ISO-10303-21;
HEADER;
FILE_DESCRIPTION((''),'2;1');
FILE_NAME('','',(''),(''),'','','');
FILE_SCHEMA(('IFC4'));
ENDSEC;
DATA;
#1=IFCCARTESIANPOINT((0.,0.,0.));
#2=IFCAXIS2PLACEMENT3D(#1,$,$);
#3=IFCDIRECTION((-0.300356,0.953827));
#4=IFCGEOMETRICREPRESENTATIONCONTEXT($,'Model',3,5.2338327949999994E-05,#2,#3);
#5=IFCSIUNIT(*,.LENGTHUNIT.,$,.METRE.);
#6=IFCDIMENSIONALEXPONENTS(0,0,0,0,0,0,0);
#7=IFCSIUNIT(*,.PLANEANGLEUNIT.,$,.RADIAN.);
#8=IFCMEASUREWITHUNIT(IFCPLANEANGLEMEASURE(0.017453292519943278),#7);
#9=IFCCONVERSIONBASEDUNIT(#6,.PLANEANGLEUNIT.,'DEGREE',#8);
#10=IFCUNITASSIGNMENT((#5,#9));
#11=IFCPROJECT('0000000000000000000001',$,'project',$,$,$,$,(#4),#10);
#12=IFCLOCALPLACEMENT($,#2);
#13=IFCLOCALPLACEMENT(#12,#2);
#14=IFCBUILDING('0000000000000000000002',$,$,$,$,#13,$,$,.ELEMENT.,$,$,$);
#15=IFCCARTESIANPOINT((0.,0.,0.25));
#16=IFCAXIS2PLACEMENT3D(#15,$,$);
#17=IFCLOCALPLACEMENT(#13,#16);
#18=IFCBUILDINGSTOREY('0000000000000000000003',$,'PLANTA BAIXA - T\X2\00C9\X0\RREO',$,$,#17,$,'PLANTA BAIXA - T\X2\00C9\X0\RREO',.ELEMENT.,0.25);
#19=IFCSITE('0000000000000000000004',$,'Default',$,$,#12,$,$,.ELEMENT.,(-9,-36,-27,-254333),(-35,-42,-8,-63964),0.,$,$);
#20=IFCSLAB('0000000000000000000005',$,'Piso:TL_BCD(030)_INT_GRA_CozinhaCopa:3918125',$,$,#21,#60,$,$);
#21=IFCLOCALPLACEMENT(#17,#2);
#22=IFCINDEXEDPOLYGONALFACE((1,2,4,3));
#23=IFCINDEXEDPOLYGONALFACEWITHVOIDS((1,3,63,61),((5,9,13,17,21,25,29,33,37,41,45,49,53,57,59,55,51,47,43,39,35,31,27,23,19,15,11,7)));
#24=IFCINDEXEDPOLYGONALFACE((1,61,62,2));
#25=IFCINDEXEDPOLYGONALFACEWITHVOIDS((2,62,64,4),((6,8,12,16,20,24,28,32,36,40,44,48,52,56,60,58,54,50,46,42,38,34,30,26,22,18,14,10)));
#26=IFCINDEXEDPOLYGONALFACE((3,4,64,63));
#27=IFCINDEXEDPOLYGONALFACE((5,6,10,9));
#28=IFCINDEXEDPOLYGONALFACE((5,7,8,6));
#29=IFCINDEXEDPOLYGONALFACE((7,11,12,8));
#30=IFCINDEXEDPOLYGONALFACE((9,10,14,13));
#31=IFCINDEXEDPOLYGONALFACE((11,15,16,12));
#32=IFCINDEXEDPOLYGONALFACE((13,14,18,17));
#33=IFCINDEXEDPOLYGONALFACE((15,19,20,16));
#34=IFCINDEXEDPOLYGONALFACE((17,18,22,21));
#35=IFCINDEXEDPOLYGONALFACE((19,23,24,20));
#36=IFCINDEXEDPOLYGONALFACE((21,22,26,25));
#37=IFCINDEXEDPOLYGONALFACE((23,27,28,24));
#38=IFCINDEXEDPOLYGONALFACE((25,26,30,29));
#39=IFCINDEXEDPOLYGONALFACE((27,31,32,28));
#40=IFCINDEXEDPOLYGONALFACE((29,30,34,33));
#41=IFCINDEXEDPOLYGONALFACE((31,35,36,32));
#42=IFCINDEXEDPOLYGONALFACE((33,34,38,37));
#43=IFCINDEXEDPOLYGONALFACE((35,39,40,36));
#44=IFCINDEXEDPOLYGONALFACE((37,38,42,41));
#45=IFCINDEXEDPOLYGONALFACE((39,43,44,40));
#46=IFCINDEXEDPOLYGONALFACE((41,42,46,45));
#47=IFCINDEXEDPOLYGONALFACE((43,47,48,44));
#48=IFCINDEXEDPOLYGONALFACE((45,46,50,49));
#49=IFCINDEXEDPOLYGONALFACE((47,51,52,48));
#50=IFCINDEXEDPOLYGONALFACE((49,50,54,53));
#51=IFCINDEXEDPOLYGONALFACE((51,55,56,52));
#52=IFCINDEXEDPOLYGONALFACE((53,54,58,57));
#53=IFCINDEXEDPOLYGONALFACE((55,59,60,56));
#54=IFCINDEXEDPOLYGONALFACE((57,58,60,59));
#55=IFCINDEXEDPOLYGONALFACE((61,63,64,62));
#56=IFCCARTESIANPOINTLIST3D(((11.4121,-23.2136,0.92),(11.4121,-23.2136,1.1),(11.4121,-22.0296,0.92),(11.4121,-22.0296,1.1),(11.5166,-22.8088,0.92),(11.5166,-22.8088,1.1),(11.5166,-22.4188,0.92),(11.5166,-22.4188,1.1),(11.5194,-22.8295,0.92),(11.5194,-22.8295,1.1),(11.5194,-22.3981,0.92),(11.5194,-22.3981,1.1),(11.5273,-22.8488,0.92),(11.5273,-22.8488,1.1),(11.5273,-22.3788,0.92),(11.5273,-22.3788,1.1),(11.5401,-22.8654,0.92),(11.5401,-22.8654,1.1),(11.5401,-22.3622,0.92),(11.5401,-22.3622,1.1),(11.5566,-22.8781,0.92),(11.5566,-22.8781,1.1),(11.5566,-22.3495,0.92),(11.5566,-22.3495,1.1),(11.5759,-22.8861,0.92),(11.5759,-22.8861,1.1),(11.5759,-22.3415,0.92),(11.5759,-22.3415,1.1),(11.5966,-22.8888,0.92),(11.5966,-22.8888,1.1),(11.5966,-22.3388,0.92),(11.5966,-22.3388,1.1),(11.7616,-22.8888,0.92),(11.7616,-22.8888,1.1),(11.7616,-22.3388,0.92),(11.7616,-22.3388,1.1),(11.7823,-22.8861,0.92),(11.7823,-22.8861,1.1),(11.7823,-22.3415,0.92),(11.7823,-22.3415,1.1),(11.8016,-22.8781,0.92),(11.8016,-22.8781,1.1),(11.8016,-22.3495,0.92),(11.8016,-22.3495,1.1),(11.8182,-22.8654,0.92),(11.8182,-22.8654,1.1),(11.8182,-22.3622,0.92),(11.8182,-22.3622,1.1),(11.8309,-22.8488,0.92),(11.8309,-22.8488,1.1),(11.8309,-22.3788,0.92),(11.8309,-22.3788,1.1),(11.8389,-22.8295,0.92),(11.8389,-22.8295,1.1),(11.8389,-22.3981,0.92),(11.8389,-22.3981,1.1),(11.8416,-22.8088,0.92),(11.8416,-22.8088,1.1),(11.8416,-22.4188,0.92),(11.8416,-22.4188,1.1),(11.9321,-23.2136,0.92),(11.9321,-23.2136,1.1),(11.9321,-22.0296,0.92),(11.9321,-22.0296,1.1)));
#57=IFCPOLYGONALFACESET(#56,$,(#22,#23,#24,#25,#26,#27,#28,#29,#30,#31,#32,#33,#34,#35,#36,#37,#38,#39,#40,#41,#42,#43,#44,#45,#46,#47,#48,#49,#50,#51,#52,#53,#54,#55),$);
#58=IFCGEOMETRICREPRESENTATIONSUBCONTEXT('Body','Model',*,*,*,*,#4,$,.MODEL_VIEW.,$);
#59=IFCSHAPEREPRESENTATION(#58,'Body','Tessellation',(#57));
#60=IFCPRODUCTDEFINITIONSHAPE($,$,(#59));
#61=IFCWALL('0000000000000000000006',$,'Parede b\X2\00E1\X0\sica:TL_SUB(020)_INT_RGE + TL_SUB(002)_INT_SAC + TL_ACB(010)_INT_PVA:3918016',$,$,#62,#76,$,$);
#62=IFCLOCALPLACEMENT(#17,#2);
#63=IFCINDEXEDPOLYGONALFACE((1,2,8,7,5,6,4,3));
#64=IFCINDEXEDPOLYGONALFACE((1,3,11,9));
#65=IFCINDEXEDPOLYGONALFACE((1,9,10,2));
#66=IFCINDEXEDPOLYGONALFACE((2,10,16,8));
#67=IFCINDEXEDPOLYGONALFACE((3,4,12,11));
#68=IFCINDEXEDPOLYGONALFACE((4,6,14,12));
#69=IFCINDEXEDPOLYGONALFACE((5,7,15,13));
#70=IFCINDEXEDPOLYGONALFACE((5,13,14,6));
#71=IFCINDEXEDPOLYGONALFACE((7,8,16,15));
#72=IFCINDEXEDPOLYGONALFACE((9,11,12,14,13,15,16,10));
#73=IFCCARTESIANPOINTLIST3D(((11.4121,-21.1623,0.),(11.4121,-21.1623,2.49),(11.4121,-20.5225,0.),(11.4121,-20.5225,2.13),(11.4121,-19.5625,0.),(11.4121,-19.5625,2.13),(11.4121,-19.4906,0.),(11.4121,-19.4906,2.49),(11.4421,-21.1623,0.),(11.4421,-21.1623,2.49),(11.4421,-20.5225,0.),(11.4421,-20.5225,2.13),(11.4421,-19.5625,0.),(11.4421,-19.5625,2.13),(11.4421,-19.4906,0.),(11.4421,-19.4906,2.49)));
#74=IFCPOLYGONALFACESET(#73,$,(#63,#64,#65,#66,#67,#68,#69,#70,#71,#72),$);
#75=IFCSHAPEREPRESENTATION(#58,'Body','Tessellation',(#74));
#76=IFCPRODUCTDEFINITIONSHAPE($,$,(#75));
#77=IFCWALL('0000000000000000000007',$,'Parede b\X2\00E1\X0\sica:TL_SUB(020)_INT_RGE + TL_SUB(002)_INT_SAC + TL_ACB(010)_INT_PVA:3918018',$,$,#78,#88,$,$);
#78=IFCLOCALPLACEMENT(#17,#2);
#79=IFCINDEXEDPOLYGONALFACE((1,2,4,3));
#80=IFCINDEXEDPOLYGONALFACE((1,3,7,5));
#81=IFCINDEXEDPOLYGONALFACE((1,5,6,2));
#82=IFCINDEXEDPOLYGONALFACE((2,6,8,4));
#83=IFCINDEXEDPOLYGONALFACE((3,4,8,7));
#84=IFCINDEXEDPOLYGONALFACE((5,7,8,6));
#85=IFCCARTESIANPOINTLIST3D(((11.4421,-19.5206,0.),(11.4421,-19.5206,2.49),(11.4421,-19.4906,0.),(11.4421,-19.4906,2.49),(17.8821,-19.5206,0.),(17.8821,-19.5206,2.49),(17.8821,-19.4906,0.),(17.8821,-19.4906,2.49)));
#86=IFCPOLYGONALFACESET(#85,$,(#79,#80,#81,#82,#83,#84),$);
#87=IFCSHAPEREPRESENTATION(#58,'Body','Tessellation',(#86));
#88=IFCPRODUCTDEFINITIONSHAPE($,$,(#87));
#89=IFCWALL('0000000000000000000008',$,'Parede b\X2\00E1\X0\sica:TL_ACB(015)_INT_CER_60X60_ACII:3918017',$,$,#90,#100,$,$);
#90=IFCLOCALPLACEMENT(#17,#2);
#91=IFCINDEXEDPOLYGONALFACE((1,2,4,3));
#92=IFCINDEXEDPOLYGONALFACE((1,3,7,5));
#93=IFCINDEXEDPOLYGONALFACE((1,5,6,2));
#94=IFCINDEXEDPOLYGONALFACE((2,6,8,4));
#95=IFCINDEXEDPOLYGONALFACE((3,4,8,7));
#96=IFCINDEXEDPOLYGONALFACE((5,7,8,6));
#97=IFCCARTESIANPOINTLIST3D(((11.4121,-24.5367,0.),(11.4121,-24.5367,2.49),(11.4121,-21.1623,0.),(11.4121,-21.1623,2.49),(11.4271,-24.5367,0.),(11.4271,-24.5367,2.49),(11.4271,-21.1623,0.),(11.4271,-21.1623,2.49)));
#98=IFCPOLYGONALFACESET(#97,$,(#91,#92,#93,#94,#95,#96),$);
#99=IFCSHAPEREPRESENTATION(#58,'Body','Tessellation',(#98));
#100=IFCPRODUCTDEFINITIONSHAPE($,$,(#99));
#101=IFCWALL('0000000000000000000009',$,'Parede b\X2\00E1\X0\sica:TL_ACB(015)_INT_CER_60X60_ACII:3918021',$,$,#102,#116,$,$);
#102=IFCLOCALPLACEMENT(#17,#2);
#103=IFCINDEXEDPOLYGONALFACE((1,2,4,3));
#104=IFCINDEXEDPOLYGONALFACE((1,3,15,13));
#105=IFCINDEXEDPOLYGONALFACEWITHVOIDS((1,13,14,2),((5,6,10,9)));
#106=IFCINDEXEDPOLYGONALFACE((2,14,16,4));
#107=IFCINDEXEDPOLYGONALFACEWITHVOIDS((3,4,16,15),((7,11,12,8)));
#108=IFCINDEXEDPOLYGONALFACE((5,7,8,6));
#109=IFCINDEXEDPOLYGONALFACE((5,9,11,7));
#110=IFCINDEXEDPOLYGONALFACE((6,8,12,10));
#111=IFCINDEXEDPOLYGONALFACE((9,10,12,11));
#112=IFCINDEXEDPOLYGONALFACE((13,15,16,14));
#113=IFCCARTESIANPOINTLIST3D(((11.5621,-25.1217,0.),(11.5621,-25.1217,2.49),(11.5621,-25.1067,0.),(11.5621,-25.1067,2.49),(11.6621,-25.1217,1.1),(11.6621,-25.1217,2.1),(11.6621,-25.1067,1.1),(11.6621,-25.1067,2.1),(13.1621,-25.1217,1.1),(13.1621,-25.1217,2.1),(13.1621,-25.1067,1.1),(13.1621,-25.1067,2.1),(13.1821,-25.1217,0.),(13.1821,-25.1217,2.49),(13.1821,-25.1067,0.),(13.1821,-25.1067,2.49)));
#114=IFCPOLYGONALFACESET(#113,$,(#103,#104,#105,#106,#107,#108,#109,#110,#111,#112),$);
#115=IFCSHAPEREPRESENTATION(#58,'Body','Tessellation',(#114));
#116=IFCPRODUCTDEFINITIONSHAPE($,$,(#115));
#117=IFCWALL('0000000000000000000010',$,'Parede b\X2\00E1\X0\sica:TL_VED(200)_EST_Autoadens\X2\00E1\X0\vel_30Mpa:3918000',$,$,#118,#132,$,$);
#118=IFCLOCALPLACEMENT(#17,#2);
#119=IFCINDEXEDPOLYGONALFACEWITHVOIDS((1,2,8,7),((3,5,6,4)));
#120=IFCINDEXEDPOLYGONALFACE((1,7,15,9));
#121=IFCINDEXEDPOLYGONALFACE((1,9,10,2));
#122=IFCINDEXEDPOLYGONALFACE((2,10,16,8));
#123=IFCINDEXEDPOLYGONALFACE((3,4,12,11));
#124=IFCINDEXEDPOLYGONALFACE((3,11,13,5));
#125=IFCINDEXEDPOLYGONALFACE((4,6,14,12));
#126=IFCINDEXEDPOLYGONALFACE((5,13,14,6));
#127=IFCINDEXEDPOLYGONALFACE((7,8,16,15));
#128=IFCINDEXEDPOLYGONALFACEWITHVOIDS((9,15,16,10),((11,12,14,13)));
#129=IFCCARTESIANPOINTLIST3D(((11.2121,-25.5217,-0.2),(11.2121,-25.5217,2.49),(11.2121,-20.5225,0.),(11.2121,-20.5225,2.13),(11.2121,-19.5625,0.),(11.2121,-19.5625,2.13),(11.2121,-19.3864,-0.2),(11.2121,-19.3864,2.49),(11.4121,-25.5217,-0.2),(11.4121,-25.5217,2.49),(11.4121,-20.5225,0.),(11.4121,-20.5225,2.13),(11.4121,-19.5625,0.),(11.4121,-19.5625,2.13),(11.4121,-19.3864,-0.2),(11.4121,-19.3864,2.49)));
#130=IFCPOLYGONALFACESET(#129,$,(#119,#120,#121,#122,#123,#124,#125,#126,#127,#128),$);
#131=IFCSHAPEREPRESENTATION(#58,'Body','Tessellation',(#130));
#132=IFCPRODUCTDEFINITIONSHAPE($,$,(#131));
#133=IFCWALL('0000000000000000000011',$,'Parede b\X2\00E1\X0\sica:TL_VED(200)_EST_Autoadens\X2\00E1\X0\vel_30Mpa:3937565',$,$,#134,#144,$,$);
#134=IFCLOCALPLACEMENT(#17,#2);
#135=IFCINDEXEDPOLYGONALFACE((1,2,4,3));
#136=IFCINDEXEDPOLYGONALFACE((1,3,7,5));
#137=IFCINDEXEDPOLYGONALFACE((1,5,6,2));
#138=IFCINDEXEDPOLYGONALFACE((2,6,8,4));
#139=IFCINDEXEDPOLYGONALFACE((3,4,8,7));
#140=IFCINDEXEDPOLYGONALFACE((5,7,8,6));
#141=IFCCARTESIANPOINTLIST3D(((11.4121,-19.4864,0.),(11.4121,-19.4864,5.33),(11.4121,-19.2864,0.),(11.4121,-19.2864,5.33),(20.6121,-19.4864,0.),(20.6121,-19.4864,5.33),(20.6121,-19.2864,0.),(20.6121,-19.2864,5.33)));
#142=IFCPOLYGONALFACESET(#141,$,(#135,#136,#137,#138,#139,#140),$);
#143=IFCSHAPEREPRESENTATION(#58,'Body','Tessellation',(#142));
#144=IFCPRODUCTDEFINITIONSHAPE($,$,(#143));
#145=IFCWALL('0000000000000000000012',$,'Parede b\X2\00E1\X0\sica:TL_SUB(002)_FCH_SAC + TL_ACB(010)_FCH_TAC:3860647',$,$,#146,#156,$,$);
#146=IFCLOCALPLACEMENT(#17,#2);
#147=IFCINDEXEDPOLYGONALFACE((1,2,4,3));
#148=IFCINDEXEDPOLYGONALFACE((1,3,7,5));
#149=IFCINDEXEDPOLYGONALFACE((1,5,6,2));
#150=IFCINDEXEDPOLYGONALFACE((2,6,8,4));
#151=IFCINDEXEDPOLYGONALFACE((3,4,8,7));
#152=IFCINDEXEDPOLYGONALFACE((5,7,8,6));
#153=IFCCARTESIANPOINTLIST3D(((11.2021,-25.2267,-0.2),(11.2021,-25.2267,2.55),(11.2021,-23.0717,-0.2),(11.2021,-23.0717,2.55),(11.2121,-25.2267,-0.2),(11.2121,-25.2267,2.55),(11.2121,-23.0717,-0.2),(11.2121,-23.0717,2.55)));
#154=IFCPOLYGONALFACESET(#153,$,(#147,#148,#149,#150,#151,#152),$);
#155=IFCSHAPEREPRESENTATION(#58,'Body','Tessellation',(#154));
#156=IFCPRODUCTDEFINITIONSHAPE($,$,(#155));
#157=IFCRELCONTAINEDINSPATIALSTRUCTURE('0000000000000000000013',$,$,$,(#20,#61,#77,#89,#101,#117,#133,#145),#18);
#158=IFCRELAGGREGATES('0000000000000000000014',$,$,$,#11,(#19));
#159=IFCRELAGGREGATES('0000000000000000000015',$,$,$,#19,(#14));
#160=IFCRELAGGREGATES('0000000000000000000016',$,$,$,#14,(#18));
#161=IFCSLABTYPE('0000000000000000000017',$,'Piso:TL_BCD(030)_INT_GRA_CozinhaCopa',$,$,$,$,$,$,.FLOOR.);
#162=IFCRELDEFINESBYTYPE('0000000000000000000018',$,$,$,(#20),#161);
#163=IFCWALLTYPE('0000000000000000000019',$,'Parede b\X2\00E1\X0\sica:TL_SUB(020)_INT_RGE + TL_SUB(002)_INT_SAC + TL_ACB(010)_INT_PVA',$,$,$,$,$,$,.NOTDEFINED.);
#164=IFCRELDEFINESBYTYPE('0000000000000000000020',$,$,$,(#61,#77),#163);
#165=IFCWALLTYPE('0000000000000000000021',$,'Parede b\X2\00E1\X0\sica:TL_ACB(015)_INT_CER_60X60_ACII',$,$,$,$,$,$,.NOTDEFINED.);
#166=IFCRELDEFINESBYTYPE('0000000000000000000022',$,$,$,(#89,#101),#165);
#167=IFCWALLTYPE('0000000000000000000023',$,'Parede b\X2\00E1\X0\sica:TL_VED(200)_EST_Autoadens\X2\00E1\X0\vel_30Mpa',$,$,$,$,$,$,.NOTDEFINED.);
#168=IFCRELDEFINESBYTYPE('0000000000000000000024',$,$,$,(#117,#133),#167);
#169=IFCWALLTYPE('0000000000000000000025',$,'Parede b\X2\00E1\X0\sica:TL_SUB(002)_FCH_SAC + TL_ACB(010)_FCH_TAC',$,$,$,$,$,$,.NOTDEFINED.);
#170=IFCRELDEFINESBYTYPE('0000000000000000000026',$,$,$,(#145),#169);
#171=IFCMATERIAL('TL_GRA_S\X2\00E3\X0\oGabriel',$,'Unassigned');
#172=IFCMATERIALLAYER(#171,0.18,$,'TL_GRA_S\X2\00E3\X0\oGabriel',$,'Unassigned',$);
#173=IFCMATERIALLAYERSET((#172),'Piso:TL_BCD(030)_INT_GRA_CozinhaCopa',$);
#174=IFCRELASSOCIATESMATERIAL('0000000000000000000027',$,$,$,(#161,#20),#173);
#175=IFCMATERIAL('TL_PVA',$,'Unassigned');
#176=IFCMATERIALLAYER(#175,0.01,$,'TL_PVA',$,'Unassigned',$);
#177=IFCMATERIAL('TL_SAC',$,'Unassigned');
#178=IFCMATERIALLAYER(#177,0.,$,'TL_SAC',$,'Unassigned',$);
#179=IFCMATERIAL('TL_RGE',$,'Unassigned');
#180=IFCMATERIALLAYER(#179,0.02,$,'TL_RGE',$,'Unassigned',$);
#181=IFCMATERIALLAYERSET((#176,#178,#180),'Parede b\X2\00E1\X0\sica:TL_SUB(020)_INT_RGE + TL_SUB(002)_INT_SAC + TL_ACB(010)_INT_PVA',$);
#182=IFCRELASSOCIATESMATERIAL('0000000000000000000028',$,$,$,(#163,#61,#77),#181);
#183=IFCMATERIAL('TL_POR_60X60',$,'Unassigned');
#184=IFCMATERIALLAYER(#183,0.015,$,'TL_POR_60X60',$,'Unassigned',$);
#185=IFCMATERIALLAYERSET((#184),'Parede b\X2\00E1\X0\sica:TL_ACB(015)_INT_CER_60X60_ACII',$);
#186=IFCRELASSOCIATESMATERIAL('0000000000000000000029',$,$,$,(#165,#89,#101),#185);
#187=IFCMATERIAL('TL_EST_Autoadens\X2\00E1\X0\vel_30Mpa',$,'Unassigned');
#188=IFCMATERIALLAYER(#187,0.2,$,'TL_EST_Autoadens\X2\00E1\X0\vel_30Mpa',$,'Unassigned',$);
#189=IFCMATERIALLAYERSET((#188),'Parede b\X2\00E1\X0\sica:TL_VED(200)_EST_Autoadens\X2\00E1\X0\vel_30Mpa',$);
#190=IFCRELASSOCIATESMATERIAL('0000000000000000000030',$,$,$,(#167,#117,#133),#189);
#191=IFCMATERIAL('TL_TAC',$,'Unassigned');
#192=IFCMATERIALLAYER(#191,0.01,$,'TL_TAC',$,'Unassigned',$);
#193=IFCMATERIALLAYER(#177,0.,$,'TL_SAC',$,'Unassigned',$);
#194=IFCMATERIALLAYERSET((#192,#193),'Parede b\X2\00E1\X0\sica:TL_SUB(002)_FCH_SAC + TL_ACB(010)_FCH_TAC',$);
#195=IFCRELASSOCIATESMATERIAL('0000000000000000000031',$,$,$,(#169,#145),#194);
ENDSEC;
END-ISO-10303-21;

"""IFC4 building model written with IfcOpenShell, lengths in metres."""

from ifc_helpers import new_model, entity, si_unit, converted_unit, direction, frame, frame_2d, origin, place, context, subcontext, project, spatial, polyline, circle_curve, parameter, trimmed, segment, composite_curve, rectangle, outline, extrude, material, layer, layer_set, layer_usage, type_object, element, save


model = new_model("IFC4")

# Units and contexts
model_context = context("Model", 3, precision=5.2338327949999994e-05, world=origin(), true_north=direction((-0.300356, 0.953827)))
body_context = subcontext(model_context, "Body", "Model", "MODEL_VIEW")
ifc_project = project(units=[si_unit("LENGTHUNIT", "METRE"), converted_unit("PLANEANGLEUNIT", "DEGREE", entity("IfcPlaneAngleMeasure", 0.017453292519943278), si_unit("PLANEANGLEUNIT", "RADIAN"), dimensions=[0, 0, 0, 0, 0, 0, 0])], contexts=[model_context])

# Site, building, storey
site_placement = place(None, origin())
site = spatial("IfcSite", under=ifc_project, at=site_placement, Name="Default", CompositionType="ELEMENT", RefLatitude=(-9, -36, -27, -254333), RefLongitude=(-35, -42, -8, -63964), RefElevation=0.0)
building_placement = place(site_placement, origin())
building = spatial("IfcBuilding", under=site, at=building_placement, CompositionType="ELEMENT")
storey_placement = place(building_placement, frame((0.0, 0.0, 0.25)))
storey = spatial("IfcBuildingStorey", under=building, at=storey_placement, Name="PLANTA BAIXA - TÉRREO", LongName="PLANTA BAIXA - TÉRREO", CompositionType="ELEMENT", Elevation=0.25)

# Shared definitions
ifc_material_1 = material(Name="TL_POR_60X60", Category="Unassigned")

# Slab, opening
ifc_material_2 = material(Name="TL_GRA_SãoGabriel", Category="Unassigned")
ifc_layer_1 = layer(ifc_material_2, 0.18, Name="TL_GRA_SãoGabriel", Category="Unassigned")
ifc_layer_set_1 = layer_set([ifc_layer_1], Name="Piso:TL_BCD(030)_INT_GRA_CozinhaCopa")
ifc_layer_usage_1 = layer_usage(ifc_layer_set_1, "AXIS3", "POSITIVE", 0.0)
slab_type_1 = type_object("IfcSlabType", Name="Piso:TL_BCD(030)_INT_GRA_CozinhaCopa", PredefinedType="FLOOR", material=ifc_layer_set_1)
slab_1_placement = place(storey_placement, frame((11.4121, -23.2136, 0.92)))
slab_1 = element("IfcSlab", 1, at=slab_1_placement, inside=storey, type_object=slab_type_1, material=ifc_layer_usage_1, Name="Piso:TL_BCD(030)_INT_GRA_CozinhaCopa:3918125", context=body_context, shape_type="SweptSolid", body=[
    extrude(rectangle(XDim=1.184, YDim=0.52, at=frame_2d((0.0, 0.0), x_axis=(0.0, 1.0))), frame((0.26, 0.592, 0.18), z_axis=(0.0, 0.0, -1.0), x_axis=(-1.0, 0.0, 0.0)), (0.0, 0.0, 1.0), 0.18),
])
opening_1_placement = place(slab_1_placement, frame((-11.4121, 23.2136, 0.18)))
element("IfcOpeningElement", 2, at=opening_1_placement, cuts=slab_1, PredefinedType="OPENING", context=body_context, shape_type="SweptSolid", body=[
    extrude(outline(composite_curve([segment(polyline([(-0.195, -0.1625), (0.195, -0.1625)]), True, "CONTINUOUS"), segment(trimmed(circle_curve(frame_2d((0.195, -0.0825), x_axis=(-1.0, 0.0)), 0.08), [parameter(90.0)], [parameter(180.0)], True, "PARAMETER"), True, "CONTINUOUS"), segment(polyline([(0.275, -0.0825), (0.275, 0.0825)]), True, "CONTINUOUS"), segment(trimmed(circle_curve(frame_2d((0.195, 0.0825), x_axis=(-1.0, 0.0)), 0.08), [parameter(180.0)], [parameter(270.0)], True, "PARAMETER"), True, "CONTINUOUS"), segment(polyline([(0.195, 0.1625), (-0.195, 0.1625)]), True, "CONTINUOUS"), segment(trimmed(circle_curve(frame_2d((-0.195, 0.0825), x_axis=(-1.0, 0.0)), 0.08), [parameter(270.0)], [parameter(360.0)], True, "PARAMETER"), True, "CONTINUOUS"), segment(polyline([(-0.275, 0.0825), (-0.275, -0.0825)]), True, "CONTINUOUS"), segment(trimmed(circle_curve(frame_2d((-0.195, -0.0825), x_axis=(-1.0, 0.0)), 0.08), [parameter(360.0)], [parameter(90.0)], True, "PARAMETER"), True, "CONTINUOUS")], self_intersect=False)), frame((11.6791, -22.6138, -0.21), z_axis=(0.0, 0.0, 1.0), x_axis=(0.0, -1.0, 0.0)), (0.0, 0.0, 1.0), 0.21),
])

# Wall, opening
ifc_material_3 = material(Name="TL_PVA", Category="Unassigned")
ifc_layer_2 = layer(ifc_material_3, 0.01, Name="TL_PVA", Category="Unassigned")
ifc_material_4 = material(Name="TL_SAC", Category="Unassigned")
ifc_layer_3 = layer(ifc_material_4, 0.0, Name="TL_SAC", Category="Unassigned")
ifc_material_5 = material(Name="TL_RGE", Category="Unassigned")
ifc_layer_4 = layer(ifc_material_5, 0.02, Name="TL_RGE", Category="Unassigned")
ifc_layer_set_2 = layer_set([ifc_layer_2, ifc_layer_3, ifc_layer_4], Name="Parede básica:TL_SUB(020)_INT_RGE + TL_SUB(002)_INT_SAC + TL_ACB(010)_INT_PVA")
ifc_layer_usage_2 = layer_usage(ifc_layer_set_2, "AXIS2", "NEGATIVE", 0.015)
wall_type_1 = type_object("IfcWallType", Name="Parede básica:TL_SUB(020)_INT_RGE + TL_SUB(002)_INT_SAC + TL_ACB(010)_INT_PVA", PredefinedType="NOTDEFINED", material=ifc_layer_set_2)
wall_1_placement = place(storey_placement, frame((11.4271, -19.4906, 0.0), z_axis=(0.0, 0.0, 1.0), x_axis=(0.0, -1.0, 0.0)))
wall_1 = element("IfcWall", 3, at=wall_1_placement, inside=storey, type_object=wall_type_1, material=ifc_layer_usage_2, Name="Parede básica:TL_SUB(020)_INT_RGE + TL_SUB(002)_INT_SAC + TL_ACB(010)_INT_PVA:3918016", context=body_context, shape_type="SweptSolid", body=[
    extrude(rectangle(XDim=1.6717, YDim=0.03, at=frame_2d((0.8359, 0.0), x_axis=(-1.0, 0.0))), origin(), (0.0, 0.0, 1.0), 2.49),
])
opening_2_placement = place(wall_1_placement, frame((-19.4906, -11.4271, 0.0)))
element("IfcOpeningElement", 4, at=opening_2_placement, cuts=wall_1, PredefinedType="OPENING", context=body_context, shape_type="SweptSolid", body=[
    extrude(rectangle(XDim=2.13, YDim=0.96, at=frame_2d((0.0, 0.0), x_axis=(0.0, 1.0))), frame((20.0425, 9.8881, 1.065), z_axis=(0.0, 1.0, 0.0), x_axis=(-1.0, 0.0, 0.0)), (0.0, 0.0, 1.0), 3.048),
])

# Walls
ifc_layer_usage_3 = layer_usage(ifc_layer_set_2, "AXIS2", "POSITIVE", -0.015)
wall_2_placement = place(storey_placement, frame((11.4421, -19.5056, 0.0)))
element("IfcWall", 5, at=wall_2_placement, inside=storey, type_object=wall_type_1, material=ifc_layer_usage_3, Name="Parede básica:TL_SUB(020)_INT_RGE + TL_SUB(002)_INT_SAC + TL_ACB(010)_INT_PVA:3918018", context=body_context, shape_type="SweptSolid", body=[
    extrude(rectangle(XDim=6.44, YDim=0.03, at=frame_2d((3.22, 0.0), x_axis=(-1.0, 0.0))), origin(), (0.0, 0.0, 1.0), 2.49),
])
ifc_layer_5 = layer(ifc_material_1, 0.015, Name="TL_POR_60X60", Category="Unassigned")
ifc_layer_set_3 = layer_set([ifc_layer_5], Name="Parede básica:TL_ACB(015)_INT_CER_60X60_ACII")
ifc_layer_usage_4 = layer_usage(ifc_layer_set_3, "AXIS2", "NEGATIVE", 0.0075)
wall_type_2 = type_object("IfcWallType", Name="Parede básica:TL_ACB(015)_INT_CER_60X60_ACII", PredefinedType="NOTDEFINED", material=ifc_layer_set_3)
wall_3_placement = place(storey_placement, frame((11.4196, -21.1623, 0.0), z_axis=(0.0, 0.0, 1.0), x_axis=(0.0, -1.0, 0.0)))
element("IfcWall", 6, at=wall_3_placement, inside=storey, type_object=wall_type_2, material=ifc_layer_usage_4, Name="Parede básica:TL_ACB(015)_INT_CER_60X60_ACII:3918017", context=body_context, shape_type="SweptSolid", body=[
    extrude(rectangle(XDim=3.3744, YDim=0.015, at=frame_2d((1.6872, 0.0), x_axis=(-1.0, 0.0))), origin(), (0.0, 0.0, 1.0), 2.49),
])

# Walls, openings
ifc_layer_usage_5 = layer_usage(ifc_layer_set_3, "AXIS2", "NEGATIVE", 0.0075)
wall_4_placement = place(storey_placement, frame((11.5621, -25.1142, 0.0)))
wall_4 = element("IfcWall", 7, at=wall_4_placement, inside=storey, type_object=wall_type_2, material=ifc_layer_usage_5, Name="Parede básica:TL_ACB(015)_INT_CER_60X60_ACII:3918021", context=body_context, shape_type="SweptSolid", body=[
    extrude(rectangle(XDim=1.62, YDim=0.015, at=frame_2d((0.81, 0.0), x_axis=(-1.0, 0.0))), origin(), (0.0, 0.0, 1.0), 2.49),
])
opening_3_placement = place(wall_4_placement, frame((-11.5621, 25.1142, 1.1)))
element("IfcOpeningElement", 8, at=opening_3_placement, cuts=wall_4, PredefinedType="OPENING", context=body_context, shape_type="SweptSolid", body=[
    extrude(rectangle(XDim=1.0, YDim=1.5, at=frame_2d((0.0, 0.0), x_axis=(0.0, 1.0))), frame((12.4121, -26.6457, 0.5), z_axis=(0.0, 1.0, 0.0), x_axis=(1.0, 0.0, 0.0)), (0.0, 0.0, 1.0), 3.048),
])
ifc_material_6 = material(Name="TL_EST_Autoadensável_30Mpa", Category="Unassigned")
ifc_layer_6 = layer(ifc_material_6, 0.2, Name="TL_EST_Autoadensável_30Mpa", Category="Unassigned")
ifc_layer_set_4 = layer_set([ifc_layer_6], Name="Parede básica:TL_VED(200)_EST_Autoadensável_30Mpa")
ifc_layer_usage_6 = layer_usage(ifc_layer_set_4, "AXIS2", "NEGATIVE", 0.1)
wall_type_3 = type_object("IfcWallType", Name="Parede básica:TL_VED(200)_EST_Autoadensável_30Mpa", PredefinedType="NOTDEFINED", material=ifc_layer_set_4)
wall_5_placement = place(storey_placement, frame((11.3121, -25.5217, -0.2), z_axis=(0.0, 0.0, 1.0), x_axis=(0.0, 1.0, 0.0)))
wall_5 = element("IfcWall", 9, at=wall_5_placement, inside=storey, type_object=wall_type_3, material=ifc_layer_usage_6, Name="Parede básica:TL_VED(200)_EST_Autoadensável_30Mpa:3918000", context=body_context, shape_type="SweptSolid", body=[
    extrude(rectangle(XDim=6.1354, YDim=0.2, at=frame_2d((3.0677, 0.0), x_axis=(-1.0, 0.0))), origin(), (0.0, 0.0, 1.0), 2.69),
])
opening_4_placement = place(wall_5_placement, frame((5.9592, 0.1, 0.2)))
element("IfcOpeningElement", 10, at=opening_4_placement, cuts=wall_5, PredefinedType="OPENING", context=body_context, shape_type="SweptSolid", body=[
    extrude(rectangle(XDim=2.13, YDim=0.96, at=frame_2d((1.065, 0.48), x_axis=(1.0, 0.0))), frame((0.0, 0.0, 0.0), z_axis=(0.0, -1.0, 0.0), x_axis=(0.0, 0.0, 1.0)), (0.0, 0.0, 1.0), 0.2),
])

# Walls
ifc_layer_usage_7 = layer_usage(ifc_layer_set_4, "AXIS2", "POSITIVE", -0.1)
wall_6_placement = place(storey_placement, frame((11.4121, -19.3864, 0.0)))
element("IfcWall", 11, at=wall_6_placement, inside=storey, type_object=wall_type_3, material=ifc_layer_usage_7, Name="Parede básica:TL_VED(200)_EST_Autoadensável_30Mpa:3937565", context=body_context, shape_type="SweptSolid", body=[
    extrude(rectangle(XDim=9.2, YDim=0.2, at=frame_2d((4.6, 0.0), x_axis=(-1.0, 0.0))), origin(), (0.0, 0.0, 1.0), 5.33),
])
ifc_material_7 = material(Name="TL_TAC", Category="Unassigned")
ifc_layer_7 = layer(ifc_material_7, 0.01, Name="TL_TAC", Category="Unassigned")
ifc_layer_8 = layer(ifc_material_4, 0.0, Name="TL_SAC", Category="Unassigned")
ifc_layer_set_5 = layer_set([ifc_layer_7, ifc_layer_8], Name="Parede básica:TL_SUB(002)_FCH_SAC + TL_ACB(010)_FCH_TAC")
ifc_layer_usage_8 = layer_usage(ifc_layer_set_5, "AXIS2", "NEGATIVE", 0.005)
wall_type_4 = type_object("IfcWallType", Name="Parede básica:TL_SUB(002)_FCH_SAC + TL_ACB(010)_FCH_TAC", PredefinedType="NOTDEFINED", material=ifc_layer_set_5)
wall_7_placement = place(storey_placement, frame((11.2071, -23.0717, -0.2), z_axis=(0.0, 0.0, 1.0), x_axis=(0.0, -1.0, 0.0)))
element("IfcWall", 12, at=wall_7_placement, inside=storey, type_object=wall_type_4, material=ifc_layer_usage_8, Name="Parede básica:TL_SUB(002)_FCH_SAC + TL_ACB(010)_FCH_TAC:3860647", context=body_context, shape_type="SweptSolid", body=[
    extrude(rectangle(XDim=2.155, YDim=0.01, at=frame_2d((1.0775, 0.0), x_axis=(-1.0, 0.0))), origin(), (0.0, 0.0, 1.0), 2.75),
])

save(model, "model.ifc")
